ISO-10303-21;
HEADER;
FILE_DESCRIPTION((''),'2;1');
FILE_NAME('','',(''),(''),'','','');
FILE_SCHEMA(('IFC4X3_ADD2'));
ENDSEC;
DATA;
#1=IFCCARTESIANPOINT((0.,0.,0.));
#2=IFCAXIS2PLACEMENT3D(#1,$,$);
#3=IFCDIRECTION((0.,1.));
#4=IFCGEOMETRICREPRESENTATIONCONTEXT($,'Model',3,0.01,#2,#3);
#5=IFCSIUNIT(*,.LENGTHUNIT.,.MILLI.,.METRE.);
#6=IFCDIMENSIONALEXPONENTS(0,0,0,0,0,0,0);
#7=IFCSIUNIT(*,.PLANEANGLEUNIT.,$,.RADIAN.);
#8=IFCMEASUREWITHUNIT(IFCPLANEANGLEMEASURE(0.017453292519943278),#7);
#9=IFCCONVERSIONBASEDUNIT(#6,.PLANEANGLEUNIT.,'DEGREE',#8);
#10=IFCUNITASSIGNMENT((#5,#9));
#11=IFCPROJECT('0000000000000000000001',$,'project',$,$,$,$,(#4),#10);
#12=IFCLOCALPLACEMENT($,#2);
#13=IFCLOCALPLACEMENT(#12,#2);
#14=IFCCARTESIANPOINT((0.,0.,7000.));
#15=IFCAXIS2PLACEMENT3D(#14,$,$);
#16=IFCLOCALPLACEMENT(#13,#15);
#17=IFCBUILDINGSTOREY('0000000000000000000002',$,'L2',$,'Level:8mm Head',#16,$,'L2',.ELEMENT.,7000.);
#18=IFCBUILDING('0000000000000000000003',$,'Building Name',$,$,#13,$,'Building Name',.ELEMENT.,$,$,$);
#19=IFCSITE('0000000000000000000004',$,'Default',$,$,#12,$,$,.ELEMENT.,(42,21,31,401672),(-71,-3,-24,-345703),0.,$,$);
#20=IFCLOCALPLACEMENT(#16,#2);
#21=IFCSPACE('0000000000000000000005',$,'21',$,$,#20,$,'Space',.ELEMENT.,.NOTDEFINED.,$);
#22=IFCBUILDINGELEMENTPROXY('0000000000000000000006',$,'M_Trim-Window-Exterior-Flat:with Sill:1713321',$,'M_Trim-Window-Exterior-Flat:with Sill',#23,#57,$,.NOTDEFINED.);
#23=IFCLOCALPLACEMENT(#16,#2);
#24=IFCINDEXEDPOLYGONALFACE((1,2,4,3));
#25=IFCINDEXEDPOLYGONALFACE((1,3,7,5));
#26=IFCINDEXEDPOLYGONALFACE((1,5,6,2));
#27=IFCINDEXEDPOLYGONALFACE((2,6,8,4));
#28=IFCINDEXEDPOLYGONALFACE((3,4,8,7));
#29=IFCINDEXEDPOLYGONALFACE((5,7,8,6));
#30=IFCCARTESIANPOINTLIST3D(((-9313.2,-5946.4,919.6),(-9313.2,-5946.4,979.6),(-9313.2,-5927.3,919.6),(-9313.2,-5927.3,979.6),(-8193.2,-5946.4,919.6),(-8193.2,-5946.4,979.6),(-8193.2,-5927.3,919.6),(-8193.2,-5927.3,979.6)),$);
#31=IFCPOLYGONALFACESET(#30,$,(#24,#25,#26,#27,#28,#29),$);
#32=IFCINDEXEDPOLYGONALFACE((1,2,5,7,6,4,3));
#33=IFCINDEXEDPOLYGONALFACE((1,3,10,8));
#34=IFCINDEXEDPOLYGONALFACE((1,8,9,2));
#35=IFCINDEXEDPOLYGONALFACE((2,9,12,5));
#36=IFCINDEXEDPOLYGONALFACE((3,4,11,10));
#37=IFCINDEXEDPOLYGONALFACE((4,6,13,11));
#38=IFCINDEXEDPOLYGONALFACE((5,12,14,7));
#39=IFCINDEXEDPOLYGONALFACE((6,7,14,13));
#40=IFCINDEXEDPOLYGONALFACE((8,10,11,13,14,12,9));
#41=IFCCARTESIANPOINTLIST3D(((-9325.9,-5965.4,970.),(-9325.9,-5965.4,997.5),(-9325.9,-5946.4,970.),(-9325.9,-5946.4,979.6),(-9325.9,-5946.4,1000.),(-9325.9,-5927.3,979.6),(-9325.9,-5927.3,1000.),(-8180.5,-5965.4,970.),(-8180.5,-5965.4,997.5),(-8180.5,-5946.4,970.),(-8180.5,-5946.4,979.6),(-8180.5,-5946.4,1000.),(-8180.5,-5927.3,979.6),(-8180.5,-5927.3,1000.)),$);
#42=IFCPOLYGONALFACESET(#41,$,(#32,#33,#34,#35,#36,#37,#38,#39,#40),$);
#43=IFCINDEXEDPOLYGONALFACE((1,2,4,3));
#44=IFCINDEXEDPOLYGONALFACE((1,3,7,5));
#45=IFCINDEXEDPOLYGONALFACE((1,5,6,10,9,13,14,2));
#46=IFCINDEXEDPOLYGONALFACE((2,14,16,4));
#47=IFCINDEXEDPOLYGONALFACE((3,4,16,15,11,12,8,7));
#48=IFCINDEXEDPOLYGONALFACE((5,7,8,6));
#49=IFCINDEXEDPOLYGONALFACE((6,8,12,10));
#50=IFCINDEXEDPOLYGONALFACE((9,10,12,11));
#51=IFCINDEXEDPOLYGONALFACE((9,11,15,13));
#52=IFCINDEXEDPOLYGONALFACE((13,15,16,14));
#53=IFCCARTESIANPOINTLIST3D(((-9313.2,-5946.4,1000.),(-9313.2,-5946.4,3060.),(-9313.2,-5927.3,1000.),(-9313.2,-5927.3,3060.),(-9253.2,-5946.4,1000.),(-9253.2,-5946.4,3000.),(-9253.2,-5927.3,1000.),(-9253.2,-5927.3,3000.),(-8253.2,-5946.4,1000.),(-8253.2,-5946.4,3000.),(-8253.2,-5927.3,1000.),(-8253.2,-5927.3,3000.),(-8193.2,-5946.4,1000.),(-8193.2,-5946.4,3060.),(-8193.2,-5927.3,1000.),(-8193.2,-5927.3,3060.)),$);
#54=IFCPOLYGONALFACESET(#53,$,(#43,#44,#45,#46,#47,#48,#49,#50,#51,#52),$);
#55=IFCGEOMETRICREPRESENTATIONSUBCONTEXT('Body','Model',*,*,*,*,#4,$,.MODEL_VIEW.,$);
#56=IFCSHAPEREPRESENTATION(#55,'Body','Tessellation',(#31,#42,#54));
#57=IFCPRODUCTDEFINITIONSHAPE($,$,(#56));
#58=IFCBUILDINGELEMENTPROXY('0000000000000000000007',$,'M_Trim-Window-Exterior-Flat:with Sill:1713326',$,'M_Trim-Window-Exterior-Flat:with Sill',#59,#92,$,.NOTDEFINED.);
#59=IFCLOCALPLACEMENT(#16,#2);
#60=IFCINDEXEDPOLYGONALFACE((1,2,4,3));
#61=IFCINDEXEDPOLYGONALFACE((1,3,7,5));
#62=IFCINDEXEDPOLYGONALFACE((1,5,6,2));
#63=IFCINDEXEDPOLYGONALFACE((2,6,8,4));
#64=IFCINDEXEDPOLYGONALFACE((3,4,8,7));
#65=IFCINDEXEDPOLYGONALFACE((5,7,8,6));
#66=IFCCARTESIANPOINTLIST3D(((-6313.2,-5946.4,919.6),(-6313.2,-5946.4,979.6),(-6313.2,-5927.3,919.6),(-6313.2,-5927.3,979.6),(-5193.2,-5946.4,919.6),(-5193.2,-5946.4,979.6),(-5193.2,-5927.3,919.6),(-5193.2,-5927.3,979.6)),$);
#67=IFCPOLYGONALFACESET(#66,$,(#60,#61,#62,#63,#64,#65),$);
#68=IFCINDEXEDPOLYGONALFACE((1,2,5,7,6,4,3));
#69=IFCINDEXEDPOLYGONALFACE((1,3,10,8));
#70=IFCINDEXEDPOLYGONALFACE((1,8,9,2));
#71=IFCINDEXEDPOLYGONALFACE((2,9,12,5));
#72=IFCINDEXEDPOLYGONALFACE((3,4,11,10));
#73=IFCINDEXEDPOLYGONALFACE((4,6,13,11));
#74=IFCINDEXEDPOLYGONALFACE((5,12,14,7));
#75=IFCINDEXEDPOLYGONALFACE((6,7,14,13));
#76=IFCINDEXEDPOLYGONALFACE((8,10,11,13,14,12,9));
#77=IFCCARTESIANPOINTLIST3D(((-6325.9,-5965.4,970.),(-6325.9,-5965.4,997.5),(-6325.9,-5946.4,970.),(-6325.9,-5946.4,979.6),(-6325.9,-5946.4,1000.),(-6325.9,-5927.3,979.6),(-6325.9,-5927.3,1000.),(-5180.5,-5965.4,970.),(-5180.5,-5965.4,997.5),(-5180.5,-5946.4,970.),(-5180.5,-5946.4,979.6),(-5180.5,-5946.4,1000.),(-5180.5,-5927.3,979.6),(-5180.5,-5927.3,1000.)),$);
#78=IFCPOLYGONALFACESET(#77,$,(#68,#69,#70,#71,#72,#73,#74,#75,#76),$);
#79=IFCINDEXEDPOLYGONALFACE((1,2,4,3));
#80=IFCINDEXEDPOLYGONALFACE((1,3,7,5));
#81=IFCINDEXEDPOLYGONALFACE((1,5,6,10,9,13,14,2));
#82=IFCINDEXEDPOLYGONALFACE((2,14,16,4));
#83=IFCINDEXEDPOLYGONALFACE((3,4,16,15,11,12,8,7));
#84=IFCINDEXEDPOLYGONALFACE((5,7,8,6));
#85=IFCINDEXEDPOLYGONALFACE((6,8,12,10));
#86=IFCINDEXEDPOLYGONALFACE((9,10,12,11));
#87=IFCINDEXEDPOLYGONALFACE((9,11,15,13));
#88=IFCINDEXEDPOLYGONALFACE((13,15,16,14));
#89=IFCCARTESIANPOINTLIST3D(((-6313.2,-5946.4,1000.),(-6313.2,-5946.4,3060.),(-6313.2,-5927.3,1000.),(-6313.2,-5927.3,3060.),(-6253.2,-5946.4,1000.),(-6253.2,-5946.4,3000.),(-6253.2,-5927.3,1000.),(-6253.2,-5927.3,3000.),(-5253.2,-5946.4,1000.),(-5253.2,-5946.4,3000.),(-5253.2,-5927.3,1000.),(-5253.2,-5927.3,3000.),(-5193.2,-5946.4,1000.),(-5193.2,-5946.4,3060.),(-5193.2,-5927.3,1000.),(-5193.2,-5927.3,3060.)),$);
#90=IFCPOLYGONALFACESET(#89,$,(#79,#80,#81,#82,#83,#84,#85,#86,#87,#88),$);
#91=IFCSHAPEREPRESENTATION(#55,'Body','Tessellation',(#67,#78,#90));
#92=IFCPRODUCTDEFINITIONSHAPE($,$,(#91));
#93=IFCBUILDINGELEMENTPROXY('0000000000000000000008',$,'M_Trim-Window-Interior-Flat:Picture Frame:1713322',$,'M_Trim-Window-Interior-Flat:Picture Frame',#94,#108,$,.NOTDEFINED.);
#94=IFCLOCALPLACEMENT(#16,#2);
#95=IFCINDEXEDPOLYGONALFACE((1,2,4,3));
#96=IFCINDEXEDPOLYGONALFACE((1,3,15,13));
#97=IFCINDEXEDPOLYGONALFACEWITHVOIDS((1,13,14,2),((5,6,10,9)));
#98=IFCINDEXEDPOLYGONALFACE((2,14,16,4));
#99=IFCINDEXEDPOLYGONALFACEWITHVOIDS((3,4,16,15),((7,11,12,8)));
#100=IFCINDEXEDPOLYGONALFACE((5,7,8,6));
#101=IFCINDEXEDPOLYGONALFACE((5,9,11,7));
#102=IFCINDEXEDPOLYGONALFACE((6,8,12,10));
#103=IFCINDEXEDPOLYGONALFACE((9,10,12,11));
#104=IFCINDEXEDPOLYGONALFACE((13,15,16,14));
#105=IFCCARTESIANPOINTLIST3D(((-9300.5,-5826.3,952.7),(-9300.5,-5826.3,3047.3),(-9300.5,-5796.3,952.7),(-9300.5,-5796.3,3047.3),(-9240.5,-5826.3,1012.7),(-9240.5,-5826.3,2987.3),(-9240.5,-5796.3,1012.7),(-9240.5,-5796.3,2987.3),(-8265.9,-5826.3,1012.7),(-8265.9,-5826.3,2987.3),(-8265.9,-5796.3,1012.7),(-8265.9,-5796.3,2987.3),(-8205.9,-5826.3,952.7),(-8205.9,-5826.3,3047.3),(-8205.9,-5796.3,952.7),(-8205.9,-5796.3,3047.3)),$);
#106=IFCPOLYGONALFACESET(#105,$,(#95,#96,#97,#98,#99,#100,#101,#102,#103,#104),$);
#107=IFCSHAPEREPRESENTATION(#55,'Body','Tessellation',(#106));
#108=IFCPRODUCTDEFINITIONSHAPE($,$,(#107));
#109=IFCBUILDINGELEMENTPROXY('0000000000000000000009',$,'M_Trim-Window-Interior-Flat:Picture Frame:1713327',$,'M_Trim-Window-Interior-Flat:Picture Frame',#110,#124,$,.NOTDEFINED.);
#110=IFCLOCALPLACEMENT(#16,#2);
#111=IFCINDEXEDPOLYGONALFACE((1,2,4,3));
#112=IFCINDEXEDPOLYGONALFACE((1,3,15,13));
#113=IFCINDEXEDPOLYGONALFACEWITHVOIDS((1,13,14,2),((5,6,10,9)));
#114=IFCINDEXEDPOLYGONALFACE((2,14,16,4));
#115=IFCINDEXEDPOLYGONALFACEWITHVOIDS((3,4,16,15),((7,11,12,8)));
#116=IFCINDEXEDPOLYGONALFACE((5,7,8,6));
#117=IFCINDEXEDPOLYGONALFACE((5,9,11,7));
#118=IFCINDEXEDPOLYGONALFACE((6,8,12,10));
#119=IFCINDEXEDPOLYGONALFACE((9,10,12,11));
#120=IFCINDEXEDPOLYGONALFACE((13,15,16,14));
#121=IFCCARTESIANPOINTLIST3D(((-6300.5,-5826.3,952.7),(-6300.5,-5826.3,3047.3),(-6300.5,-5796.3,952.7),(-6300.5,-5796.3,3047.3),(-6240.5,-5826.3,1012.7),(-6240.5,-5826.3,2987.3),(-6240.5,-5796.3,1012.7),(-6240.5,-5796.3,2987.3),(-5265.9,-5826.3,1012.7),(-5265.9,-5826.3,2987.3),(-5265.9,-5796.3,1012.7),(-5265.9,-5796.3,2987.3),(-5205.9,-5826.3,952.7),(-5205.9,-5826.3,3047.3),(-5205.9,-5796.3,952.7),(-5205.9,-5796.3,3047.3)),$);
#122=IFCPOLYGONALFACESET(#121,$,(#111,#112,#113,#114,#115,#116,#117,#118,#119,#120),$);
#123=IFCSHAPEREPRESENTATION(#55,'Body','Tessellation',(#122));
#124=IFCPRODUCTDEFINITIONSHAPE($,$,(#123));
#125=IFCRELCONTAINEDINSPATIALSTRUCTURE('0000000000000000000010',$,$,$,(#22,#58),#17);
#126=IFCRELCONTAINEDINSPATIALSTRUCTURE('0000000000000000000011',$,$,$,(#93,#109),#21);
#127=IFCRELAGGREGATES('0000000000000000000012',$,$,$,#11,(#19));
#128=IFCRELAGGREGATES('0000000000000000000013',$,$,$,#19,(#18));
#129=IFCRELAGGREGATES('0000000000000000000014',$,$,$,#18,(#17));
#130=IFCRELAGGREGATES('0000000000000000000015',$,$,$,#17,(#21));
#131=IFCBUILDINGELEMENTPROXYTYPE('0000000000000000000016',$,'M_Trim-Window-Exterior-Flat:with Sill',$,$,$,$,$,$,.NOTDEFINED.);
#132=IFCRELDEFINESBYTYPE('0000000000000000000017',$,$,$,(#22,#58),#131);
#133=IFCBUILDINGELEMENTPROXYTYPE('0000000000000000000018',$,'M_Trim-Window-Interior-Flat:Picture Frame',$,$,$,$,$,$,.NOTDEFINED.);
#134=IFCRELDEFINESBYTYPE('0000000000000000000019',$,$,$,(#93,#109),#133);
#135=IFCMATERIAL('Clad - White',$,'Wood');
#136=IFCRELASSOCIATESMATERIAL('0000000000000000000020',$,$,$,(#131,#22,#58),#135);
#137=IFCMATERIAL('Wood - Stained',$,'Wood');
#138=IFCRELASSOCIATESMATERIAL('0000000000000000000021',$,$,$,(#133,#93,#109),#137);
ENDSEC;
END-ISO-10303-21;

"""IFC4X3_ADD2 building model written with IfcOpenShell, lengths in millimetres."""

from ifc_helpers import new_model, entity, si_unit, converted_unit, direction, frame, frame_2d, origin, place, context, subcontext, project, spatial, polyline, rectangle, outline, extrude, source, transform, mapped, material, type_object, type_shapes, element, save


model = new_model("IFC4X3_ADD2")

# Units and contexts
model_context = context("Model", 3, precision=0.01, world=origin(), true_north=direction((0.0, 1.0)))
body_context = subcontext(model_context, "Body", "Model", "MODEL_VIEW")
ifc_project = project(units=[si_unit("LENGTHUNIT", "METRE", prefix="MILLI"), converted_unit("PLANEANGLEUNIT", "DEGREE", entity("IfcPlaneAngleMeasure", 0.017453292519943278), si_unit("PLANEANGLEUNIT", "RADIAN"), dimensions=[0, 0, 0, 0, 0, 0, 0])], contexts=[model_context])

# Site, building, storey
site_placement = place(None, origin())
site = spatial("IfcSite", under=ifc_project, at=site_placement, Name="Default", CompositionType="ELEMENT", RefLatitude=(42, 21, 31, 401672), RefLongitude=(-71, -3, -24, -345703), RefElevation=0.0)
building_placement = place(site_placement, origin())
building = spatial("IfcBuilding", under=site, at=building_placement, Name="Building Name", LongName="Building Name", CompositionType="ELEMENT")
storey_placement = place(building_placement, frame((0.0, 0.0, 7000.0)))
storey = spatial("IfcBuildingStorey", under=building, at=storey_placement, Name="L2", ObjectType="Level:8mm Head", LongName="L2", CompositionType="ELEMENT", Elevation=7000.0)

# Shared definitions
ifc_material_1 = material(Name="Clad - White", Category="Wood")
ifc_material_2 = material(Name="Wood - Stained", Category="Wood")

# Building element proxies
building_element_proxy_type_1 = type_object("IfcBuildingElementProxyType", Name="M_Trim-Window-Exterior-Flat:with Sill", PredefinedType="NOTDEFINED", material=ifc_material_1)
shared_shape_1 = source(origin(), body_context, "Body", "SweptSolid", [
    extrude(rectangle(XDim=1120.0, YDim=60.0, at=frame_2d((0.0, 0.0), x_axis=(1.0, 0.0))), frame((0.0, -2050.4, 0.0), z_axis=(0.0, 0.0, 1.0), x_axis=(-1.0, 0.0, 0.0)), (0.0, 0.0, 1.0), 19.0),
    extrude(outline(polyline([(-19.0, -15.2), (0.0, -15.2), (0.0, -5.7), (19.0, -5.7), (19.0, 14.8), (0.0, 14.8), (-19.0, 12.3), (-19.0, -15.2)])), frame((-572.7, -2014.8, 19.0), z_axis=(1.0, 0.0, 0.0), x_axis=(0.0, 0.0, -1.0)), (0.0, 0.0, 1.0), 1145.4),
    extrude(outline(polyline([(-1045.0, -560.0), (1015.0, -560.0), (1015.0, -500.0), (-985.0, -500.0), (-985.0, 500.0), (1015.0, 500.0), (1015.0, 560.0), (-1045.0, 560.0), (-1045.0, -560.0)])), frame((0.0, -985.0, 0.0), z_axis=(0.0, 0.0, 1.0), x_axis=(0.0, -1.0, 0.0)), (0.0, 0.0, 1.0), 19.0),
])
type_shapes(building_element_proxy_type_1, [shared_shape_1])
for number, where, z_axis, x_axis, name in (
    (1, (-8753.2, -5927.3, 3000.0), (0.0, -1.0, 0.0), (1.0, 0.0, 0.0), "M_Trim-Window-Exterior-Flat:with Sill:1713321"),
    (2, (-5753.2, -5927.3, 3000.0), (0.0, -1.0, 0.0), (1.0, 0.0, 0.0), "M_Trim-Window-Exterior-Flat:with Sill:1713326"),
):
    element("IfcBuildingElementProxy", number, at=place(storey_placement, frame(where, z_axis=z_axis, x_axis=x_axis)), inside=storey, type_object=building_element_proxy_type_1, material=ifc_material_1, Name=name, ObjectType="M_Trim-Window-Exterior-Flat:with Sill", PredefinedType="NOTDEFINED", context=body_context, shape_type="MappedRepresentation", body=[
        mapped(shared_shape_1, transform((0.0, 0.0, 0.0), scale=1.0)),
    ])

# Shared definitions
space_1_placement = place(storey_placement, origin())
space_1 = spatial("IfcSpace", under=storey, at=space_1_placement, Name="21", LongName="Space", CompositionType="ELEMENT", PredefinedType="NOTDEFINED")

# Building element proxies
building_element_proxy_type_2 = type_object("IfcBuildingElementProxyType", Name="M_Trim-Window-Interior-Flat:Picture Frame", PredefinedType="NOTDEFINED", material=ifc_material_2)
shared_shape_2 = source(origin(), body_context, "Body", "SweptSolid", [
    extrude(outline(polyline([(-547.3, -1047.3), (547.3, -1047.3), (547.3, 1047.3), (-547.3, 1047.3), (-547.3, -1047.3)]), holes=[polyline([(-487.3, -987.3), (-487.3, 987.3), (487.3, 987.3), (487.3, -987.3), (-487.3, -987.3)])]), frame((0.0, -1000.0, 0.0), z_axis=(0.0, 0.0, 1.0), x_axis=(-1.0, 0.0, 0.0)), (0.0, 0.0, 1.0), 30.0),
])
type_shapes(building_element_proxy_type_2, [shared_shape_2])
for number, where, z_axis, x_axis, name in (
    (3, (-8753.2, -5826.3, 3000.0), (0.0, 1.0, 0.0), (-1.0, 0.0, 0.0), "M_Trim-Window-Interior-Flat:Picture Frame:1713322"),
    (4, (-5753.2, -5826.3, 3000.0), (0.0, 1.0, 0.0), (-1.0, 0.0, 0.0), "M_Trim-Window-Interior-Flat:Picture Frame:1713327"),
):
    element("IfcBuildingElementProxy", number, at=place(space_1_placement, frame(where, z_axis=z_axis, x_axis=x_axis)), inside=space_1, type_object=building_element_proxy_type_2, material=ifc_material_2, Name=name, ObjectType="M_Trim-Window-Interior-Flat:Picture Frame", PredefinedType="NOTDEFINED", context=body_context, shape_type="MappedRepresentation", body=[
        mapped(shared_shape_2, transform((0.0, 0.0, 0.0), scale=1.0)),
    ])

save(model, "model.ifc")
